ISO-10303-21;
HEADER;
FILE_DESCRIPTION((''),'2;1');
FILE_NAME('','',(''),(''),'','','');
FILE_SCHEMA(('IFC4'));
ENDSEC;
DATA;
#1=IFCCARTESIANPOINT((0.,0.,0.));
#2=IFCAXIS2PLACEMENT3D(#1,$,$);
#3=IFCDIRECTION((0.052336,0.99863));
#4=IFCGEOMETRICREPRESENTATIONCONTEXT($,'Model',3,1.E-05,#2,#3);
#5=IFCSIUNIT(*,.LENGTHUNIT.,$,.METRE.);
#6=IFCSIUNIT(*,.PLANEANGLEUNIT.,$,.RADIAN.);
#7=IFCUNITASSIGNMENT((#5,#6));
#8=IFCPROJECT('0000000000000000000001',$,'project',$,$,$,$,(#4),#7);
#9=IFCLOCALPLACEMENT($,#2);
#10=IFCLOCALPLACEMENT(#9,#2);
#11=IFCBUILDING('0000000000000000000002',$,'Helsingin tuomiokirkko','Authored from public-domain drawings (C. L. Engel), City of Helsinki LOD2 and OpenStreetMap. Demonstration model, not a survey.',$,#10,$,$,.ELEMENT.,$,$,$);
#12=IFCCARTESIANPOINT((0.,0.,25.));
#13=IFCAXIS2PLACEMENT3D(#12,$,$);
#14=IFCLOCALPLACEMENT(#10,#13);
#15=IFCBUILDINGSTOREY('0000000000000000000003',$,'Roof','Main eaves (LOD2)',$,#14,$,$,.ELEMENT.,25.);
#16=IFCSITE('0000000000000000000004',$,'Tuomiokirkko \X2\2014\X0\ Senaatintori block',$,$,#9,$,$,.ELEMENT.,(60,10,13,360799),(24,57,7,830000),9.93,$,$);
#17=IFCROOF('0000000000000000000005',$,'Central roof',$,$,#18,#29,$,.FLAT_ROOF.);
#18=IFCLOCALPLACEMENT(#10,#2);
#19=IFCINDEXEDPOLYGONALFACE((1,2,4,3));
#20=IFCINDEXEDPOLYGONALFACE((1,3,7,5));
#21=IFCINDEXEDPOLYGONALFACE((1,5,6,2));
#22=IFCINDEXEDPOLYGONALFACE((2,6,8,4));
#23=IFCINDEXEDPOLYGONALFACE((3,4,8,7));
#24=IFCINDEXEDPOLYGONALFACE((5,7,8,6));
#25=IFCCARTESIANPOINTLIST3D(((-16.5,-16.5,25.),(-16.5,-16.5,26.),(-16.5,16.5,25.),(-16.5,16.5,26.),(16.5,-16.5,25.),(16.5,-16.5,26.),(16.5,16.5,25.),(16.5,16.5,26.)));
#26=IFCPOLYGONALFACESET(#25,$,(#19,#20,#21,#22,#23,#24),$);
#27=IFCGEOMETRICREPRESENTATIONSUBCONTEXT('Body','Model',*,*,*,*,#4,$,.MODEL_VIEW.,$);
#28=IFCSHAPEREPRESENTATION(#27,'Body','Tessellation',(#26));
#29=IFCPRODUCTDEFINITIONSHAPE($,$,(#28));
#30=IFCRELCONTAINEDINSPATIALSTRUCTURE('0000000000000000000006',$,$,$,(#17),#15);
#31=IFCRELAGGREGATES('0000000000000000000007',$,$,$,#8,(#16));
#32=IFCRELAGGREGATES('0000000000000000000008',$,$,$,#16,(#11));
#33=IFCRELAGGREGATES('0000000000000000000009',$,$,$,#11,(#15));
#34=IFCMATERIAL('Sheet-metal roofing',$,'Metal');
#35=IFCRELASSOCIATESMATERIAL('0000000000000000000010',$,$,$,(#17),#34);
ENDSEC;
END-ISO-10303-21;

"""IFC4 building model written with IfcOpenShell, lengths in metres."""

from ifc_helpers import new_model, si_unit, direction, frame, origin, origin_2d_with_axis, place, context, subcontext, project, spatial, rectangle, extrude, material, element, save


model = new_model("IFC4")

# Units and contexts
model_context = context("Model", 3, precision=1e-05, world=origin(), true_north=direction((0.052336, 0.99863)))
body_context = subcontext(model_context, "Body", "Model", "MODEL_VIEW")
ifc_project = project(units=[si_unit("LENGTHUNIT", "METRE"), si_unit("PLANEANGLEUNIT", "RADIAN")], contexts=[model_context])

# Site, building, storey
site_placement = place(None, origin())
site = spatial("IfcSite", under=ifc_project, at=site_placement, Name="Tuomiokirkko — Senaatintori block", CompositionType="ELEMENT", RefLatitude=(60, 10, 13, 360799), RefLongitude=(24, 57, 7, 830000), RefElevation=9.93)
building_placement = place(site_placement, origin())
building = spatial("IfcBuilding", under=site, at=building_placement, Name="Helsingin tuomiokirkko", Description="Authored from public-domain drawings (C. L. Engel), City of Helsinki LOD2 and OpenStreetMap. Demonstration model, not a survey.", CompositionType="ELEMENT")
storey_placement = place(building_placement, frame((0.0, 0.0, 25.0)))
storey = spatial("IfcBuildingStorey", under=building, at=storey_placement, Name="Roof", Description="Main eaves (LOD2)", CompositionType="ELEMENT", Elevation=25.0)

# Roof
ifc_material_1 = material(Name="Sheet-metal roofing", Category="Metal")
roof_1_placement = place(building_placement, origin())
element("IfcRoof", 1, at=roof_1_placement, inside=storey, material=ifc_material_1, Name="Central roof", PredefinedType="FLAT_ROOF", context=body_context, shape_type="SweptSolid", body=[
    extrude(rectangle(XDim=33.0, YDim=33.0, at=origin_2d_with_axis()), frame((0.0, 0.0, 25.0)), (0.0, 0.0, 1.0), 1.0),
])

save(model, "model.ifc")
